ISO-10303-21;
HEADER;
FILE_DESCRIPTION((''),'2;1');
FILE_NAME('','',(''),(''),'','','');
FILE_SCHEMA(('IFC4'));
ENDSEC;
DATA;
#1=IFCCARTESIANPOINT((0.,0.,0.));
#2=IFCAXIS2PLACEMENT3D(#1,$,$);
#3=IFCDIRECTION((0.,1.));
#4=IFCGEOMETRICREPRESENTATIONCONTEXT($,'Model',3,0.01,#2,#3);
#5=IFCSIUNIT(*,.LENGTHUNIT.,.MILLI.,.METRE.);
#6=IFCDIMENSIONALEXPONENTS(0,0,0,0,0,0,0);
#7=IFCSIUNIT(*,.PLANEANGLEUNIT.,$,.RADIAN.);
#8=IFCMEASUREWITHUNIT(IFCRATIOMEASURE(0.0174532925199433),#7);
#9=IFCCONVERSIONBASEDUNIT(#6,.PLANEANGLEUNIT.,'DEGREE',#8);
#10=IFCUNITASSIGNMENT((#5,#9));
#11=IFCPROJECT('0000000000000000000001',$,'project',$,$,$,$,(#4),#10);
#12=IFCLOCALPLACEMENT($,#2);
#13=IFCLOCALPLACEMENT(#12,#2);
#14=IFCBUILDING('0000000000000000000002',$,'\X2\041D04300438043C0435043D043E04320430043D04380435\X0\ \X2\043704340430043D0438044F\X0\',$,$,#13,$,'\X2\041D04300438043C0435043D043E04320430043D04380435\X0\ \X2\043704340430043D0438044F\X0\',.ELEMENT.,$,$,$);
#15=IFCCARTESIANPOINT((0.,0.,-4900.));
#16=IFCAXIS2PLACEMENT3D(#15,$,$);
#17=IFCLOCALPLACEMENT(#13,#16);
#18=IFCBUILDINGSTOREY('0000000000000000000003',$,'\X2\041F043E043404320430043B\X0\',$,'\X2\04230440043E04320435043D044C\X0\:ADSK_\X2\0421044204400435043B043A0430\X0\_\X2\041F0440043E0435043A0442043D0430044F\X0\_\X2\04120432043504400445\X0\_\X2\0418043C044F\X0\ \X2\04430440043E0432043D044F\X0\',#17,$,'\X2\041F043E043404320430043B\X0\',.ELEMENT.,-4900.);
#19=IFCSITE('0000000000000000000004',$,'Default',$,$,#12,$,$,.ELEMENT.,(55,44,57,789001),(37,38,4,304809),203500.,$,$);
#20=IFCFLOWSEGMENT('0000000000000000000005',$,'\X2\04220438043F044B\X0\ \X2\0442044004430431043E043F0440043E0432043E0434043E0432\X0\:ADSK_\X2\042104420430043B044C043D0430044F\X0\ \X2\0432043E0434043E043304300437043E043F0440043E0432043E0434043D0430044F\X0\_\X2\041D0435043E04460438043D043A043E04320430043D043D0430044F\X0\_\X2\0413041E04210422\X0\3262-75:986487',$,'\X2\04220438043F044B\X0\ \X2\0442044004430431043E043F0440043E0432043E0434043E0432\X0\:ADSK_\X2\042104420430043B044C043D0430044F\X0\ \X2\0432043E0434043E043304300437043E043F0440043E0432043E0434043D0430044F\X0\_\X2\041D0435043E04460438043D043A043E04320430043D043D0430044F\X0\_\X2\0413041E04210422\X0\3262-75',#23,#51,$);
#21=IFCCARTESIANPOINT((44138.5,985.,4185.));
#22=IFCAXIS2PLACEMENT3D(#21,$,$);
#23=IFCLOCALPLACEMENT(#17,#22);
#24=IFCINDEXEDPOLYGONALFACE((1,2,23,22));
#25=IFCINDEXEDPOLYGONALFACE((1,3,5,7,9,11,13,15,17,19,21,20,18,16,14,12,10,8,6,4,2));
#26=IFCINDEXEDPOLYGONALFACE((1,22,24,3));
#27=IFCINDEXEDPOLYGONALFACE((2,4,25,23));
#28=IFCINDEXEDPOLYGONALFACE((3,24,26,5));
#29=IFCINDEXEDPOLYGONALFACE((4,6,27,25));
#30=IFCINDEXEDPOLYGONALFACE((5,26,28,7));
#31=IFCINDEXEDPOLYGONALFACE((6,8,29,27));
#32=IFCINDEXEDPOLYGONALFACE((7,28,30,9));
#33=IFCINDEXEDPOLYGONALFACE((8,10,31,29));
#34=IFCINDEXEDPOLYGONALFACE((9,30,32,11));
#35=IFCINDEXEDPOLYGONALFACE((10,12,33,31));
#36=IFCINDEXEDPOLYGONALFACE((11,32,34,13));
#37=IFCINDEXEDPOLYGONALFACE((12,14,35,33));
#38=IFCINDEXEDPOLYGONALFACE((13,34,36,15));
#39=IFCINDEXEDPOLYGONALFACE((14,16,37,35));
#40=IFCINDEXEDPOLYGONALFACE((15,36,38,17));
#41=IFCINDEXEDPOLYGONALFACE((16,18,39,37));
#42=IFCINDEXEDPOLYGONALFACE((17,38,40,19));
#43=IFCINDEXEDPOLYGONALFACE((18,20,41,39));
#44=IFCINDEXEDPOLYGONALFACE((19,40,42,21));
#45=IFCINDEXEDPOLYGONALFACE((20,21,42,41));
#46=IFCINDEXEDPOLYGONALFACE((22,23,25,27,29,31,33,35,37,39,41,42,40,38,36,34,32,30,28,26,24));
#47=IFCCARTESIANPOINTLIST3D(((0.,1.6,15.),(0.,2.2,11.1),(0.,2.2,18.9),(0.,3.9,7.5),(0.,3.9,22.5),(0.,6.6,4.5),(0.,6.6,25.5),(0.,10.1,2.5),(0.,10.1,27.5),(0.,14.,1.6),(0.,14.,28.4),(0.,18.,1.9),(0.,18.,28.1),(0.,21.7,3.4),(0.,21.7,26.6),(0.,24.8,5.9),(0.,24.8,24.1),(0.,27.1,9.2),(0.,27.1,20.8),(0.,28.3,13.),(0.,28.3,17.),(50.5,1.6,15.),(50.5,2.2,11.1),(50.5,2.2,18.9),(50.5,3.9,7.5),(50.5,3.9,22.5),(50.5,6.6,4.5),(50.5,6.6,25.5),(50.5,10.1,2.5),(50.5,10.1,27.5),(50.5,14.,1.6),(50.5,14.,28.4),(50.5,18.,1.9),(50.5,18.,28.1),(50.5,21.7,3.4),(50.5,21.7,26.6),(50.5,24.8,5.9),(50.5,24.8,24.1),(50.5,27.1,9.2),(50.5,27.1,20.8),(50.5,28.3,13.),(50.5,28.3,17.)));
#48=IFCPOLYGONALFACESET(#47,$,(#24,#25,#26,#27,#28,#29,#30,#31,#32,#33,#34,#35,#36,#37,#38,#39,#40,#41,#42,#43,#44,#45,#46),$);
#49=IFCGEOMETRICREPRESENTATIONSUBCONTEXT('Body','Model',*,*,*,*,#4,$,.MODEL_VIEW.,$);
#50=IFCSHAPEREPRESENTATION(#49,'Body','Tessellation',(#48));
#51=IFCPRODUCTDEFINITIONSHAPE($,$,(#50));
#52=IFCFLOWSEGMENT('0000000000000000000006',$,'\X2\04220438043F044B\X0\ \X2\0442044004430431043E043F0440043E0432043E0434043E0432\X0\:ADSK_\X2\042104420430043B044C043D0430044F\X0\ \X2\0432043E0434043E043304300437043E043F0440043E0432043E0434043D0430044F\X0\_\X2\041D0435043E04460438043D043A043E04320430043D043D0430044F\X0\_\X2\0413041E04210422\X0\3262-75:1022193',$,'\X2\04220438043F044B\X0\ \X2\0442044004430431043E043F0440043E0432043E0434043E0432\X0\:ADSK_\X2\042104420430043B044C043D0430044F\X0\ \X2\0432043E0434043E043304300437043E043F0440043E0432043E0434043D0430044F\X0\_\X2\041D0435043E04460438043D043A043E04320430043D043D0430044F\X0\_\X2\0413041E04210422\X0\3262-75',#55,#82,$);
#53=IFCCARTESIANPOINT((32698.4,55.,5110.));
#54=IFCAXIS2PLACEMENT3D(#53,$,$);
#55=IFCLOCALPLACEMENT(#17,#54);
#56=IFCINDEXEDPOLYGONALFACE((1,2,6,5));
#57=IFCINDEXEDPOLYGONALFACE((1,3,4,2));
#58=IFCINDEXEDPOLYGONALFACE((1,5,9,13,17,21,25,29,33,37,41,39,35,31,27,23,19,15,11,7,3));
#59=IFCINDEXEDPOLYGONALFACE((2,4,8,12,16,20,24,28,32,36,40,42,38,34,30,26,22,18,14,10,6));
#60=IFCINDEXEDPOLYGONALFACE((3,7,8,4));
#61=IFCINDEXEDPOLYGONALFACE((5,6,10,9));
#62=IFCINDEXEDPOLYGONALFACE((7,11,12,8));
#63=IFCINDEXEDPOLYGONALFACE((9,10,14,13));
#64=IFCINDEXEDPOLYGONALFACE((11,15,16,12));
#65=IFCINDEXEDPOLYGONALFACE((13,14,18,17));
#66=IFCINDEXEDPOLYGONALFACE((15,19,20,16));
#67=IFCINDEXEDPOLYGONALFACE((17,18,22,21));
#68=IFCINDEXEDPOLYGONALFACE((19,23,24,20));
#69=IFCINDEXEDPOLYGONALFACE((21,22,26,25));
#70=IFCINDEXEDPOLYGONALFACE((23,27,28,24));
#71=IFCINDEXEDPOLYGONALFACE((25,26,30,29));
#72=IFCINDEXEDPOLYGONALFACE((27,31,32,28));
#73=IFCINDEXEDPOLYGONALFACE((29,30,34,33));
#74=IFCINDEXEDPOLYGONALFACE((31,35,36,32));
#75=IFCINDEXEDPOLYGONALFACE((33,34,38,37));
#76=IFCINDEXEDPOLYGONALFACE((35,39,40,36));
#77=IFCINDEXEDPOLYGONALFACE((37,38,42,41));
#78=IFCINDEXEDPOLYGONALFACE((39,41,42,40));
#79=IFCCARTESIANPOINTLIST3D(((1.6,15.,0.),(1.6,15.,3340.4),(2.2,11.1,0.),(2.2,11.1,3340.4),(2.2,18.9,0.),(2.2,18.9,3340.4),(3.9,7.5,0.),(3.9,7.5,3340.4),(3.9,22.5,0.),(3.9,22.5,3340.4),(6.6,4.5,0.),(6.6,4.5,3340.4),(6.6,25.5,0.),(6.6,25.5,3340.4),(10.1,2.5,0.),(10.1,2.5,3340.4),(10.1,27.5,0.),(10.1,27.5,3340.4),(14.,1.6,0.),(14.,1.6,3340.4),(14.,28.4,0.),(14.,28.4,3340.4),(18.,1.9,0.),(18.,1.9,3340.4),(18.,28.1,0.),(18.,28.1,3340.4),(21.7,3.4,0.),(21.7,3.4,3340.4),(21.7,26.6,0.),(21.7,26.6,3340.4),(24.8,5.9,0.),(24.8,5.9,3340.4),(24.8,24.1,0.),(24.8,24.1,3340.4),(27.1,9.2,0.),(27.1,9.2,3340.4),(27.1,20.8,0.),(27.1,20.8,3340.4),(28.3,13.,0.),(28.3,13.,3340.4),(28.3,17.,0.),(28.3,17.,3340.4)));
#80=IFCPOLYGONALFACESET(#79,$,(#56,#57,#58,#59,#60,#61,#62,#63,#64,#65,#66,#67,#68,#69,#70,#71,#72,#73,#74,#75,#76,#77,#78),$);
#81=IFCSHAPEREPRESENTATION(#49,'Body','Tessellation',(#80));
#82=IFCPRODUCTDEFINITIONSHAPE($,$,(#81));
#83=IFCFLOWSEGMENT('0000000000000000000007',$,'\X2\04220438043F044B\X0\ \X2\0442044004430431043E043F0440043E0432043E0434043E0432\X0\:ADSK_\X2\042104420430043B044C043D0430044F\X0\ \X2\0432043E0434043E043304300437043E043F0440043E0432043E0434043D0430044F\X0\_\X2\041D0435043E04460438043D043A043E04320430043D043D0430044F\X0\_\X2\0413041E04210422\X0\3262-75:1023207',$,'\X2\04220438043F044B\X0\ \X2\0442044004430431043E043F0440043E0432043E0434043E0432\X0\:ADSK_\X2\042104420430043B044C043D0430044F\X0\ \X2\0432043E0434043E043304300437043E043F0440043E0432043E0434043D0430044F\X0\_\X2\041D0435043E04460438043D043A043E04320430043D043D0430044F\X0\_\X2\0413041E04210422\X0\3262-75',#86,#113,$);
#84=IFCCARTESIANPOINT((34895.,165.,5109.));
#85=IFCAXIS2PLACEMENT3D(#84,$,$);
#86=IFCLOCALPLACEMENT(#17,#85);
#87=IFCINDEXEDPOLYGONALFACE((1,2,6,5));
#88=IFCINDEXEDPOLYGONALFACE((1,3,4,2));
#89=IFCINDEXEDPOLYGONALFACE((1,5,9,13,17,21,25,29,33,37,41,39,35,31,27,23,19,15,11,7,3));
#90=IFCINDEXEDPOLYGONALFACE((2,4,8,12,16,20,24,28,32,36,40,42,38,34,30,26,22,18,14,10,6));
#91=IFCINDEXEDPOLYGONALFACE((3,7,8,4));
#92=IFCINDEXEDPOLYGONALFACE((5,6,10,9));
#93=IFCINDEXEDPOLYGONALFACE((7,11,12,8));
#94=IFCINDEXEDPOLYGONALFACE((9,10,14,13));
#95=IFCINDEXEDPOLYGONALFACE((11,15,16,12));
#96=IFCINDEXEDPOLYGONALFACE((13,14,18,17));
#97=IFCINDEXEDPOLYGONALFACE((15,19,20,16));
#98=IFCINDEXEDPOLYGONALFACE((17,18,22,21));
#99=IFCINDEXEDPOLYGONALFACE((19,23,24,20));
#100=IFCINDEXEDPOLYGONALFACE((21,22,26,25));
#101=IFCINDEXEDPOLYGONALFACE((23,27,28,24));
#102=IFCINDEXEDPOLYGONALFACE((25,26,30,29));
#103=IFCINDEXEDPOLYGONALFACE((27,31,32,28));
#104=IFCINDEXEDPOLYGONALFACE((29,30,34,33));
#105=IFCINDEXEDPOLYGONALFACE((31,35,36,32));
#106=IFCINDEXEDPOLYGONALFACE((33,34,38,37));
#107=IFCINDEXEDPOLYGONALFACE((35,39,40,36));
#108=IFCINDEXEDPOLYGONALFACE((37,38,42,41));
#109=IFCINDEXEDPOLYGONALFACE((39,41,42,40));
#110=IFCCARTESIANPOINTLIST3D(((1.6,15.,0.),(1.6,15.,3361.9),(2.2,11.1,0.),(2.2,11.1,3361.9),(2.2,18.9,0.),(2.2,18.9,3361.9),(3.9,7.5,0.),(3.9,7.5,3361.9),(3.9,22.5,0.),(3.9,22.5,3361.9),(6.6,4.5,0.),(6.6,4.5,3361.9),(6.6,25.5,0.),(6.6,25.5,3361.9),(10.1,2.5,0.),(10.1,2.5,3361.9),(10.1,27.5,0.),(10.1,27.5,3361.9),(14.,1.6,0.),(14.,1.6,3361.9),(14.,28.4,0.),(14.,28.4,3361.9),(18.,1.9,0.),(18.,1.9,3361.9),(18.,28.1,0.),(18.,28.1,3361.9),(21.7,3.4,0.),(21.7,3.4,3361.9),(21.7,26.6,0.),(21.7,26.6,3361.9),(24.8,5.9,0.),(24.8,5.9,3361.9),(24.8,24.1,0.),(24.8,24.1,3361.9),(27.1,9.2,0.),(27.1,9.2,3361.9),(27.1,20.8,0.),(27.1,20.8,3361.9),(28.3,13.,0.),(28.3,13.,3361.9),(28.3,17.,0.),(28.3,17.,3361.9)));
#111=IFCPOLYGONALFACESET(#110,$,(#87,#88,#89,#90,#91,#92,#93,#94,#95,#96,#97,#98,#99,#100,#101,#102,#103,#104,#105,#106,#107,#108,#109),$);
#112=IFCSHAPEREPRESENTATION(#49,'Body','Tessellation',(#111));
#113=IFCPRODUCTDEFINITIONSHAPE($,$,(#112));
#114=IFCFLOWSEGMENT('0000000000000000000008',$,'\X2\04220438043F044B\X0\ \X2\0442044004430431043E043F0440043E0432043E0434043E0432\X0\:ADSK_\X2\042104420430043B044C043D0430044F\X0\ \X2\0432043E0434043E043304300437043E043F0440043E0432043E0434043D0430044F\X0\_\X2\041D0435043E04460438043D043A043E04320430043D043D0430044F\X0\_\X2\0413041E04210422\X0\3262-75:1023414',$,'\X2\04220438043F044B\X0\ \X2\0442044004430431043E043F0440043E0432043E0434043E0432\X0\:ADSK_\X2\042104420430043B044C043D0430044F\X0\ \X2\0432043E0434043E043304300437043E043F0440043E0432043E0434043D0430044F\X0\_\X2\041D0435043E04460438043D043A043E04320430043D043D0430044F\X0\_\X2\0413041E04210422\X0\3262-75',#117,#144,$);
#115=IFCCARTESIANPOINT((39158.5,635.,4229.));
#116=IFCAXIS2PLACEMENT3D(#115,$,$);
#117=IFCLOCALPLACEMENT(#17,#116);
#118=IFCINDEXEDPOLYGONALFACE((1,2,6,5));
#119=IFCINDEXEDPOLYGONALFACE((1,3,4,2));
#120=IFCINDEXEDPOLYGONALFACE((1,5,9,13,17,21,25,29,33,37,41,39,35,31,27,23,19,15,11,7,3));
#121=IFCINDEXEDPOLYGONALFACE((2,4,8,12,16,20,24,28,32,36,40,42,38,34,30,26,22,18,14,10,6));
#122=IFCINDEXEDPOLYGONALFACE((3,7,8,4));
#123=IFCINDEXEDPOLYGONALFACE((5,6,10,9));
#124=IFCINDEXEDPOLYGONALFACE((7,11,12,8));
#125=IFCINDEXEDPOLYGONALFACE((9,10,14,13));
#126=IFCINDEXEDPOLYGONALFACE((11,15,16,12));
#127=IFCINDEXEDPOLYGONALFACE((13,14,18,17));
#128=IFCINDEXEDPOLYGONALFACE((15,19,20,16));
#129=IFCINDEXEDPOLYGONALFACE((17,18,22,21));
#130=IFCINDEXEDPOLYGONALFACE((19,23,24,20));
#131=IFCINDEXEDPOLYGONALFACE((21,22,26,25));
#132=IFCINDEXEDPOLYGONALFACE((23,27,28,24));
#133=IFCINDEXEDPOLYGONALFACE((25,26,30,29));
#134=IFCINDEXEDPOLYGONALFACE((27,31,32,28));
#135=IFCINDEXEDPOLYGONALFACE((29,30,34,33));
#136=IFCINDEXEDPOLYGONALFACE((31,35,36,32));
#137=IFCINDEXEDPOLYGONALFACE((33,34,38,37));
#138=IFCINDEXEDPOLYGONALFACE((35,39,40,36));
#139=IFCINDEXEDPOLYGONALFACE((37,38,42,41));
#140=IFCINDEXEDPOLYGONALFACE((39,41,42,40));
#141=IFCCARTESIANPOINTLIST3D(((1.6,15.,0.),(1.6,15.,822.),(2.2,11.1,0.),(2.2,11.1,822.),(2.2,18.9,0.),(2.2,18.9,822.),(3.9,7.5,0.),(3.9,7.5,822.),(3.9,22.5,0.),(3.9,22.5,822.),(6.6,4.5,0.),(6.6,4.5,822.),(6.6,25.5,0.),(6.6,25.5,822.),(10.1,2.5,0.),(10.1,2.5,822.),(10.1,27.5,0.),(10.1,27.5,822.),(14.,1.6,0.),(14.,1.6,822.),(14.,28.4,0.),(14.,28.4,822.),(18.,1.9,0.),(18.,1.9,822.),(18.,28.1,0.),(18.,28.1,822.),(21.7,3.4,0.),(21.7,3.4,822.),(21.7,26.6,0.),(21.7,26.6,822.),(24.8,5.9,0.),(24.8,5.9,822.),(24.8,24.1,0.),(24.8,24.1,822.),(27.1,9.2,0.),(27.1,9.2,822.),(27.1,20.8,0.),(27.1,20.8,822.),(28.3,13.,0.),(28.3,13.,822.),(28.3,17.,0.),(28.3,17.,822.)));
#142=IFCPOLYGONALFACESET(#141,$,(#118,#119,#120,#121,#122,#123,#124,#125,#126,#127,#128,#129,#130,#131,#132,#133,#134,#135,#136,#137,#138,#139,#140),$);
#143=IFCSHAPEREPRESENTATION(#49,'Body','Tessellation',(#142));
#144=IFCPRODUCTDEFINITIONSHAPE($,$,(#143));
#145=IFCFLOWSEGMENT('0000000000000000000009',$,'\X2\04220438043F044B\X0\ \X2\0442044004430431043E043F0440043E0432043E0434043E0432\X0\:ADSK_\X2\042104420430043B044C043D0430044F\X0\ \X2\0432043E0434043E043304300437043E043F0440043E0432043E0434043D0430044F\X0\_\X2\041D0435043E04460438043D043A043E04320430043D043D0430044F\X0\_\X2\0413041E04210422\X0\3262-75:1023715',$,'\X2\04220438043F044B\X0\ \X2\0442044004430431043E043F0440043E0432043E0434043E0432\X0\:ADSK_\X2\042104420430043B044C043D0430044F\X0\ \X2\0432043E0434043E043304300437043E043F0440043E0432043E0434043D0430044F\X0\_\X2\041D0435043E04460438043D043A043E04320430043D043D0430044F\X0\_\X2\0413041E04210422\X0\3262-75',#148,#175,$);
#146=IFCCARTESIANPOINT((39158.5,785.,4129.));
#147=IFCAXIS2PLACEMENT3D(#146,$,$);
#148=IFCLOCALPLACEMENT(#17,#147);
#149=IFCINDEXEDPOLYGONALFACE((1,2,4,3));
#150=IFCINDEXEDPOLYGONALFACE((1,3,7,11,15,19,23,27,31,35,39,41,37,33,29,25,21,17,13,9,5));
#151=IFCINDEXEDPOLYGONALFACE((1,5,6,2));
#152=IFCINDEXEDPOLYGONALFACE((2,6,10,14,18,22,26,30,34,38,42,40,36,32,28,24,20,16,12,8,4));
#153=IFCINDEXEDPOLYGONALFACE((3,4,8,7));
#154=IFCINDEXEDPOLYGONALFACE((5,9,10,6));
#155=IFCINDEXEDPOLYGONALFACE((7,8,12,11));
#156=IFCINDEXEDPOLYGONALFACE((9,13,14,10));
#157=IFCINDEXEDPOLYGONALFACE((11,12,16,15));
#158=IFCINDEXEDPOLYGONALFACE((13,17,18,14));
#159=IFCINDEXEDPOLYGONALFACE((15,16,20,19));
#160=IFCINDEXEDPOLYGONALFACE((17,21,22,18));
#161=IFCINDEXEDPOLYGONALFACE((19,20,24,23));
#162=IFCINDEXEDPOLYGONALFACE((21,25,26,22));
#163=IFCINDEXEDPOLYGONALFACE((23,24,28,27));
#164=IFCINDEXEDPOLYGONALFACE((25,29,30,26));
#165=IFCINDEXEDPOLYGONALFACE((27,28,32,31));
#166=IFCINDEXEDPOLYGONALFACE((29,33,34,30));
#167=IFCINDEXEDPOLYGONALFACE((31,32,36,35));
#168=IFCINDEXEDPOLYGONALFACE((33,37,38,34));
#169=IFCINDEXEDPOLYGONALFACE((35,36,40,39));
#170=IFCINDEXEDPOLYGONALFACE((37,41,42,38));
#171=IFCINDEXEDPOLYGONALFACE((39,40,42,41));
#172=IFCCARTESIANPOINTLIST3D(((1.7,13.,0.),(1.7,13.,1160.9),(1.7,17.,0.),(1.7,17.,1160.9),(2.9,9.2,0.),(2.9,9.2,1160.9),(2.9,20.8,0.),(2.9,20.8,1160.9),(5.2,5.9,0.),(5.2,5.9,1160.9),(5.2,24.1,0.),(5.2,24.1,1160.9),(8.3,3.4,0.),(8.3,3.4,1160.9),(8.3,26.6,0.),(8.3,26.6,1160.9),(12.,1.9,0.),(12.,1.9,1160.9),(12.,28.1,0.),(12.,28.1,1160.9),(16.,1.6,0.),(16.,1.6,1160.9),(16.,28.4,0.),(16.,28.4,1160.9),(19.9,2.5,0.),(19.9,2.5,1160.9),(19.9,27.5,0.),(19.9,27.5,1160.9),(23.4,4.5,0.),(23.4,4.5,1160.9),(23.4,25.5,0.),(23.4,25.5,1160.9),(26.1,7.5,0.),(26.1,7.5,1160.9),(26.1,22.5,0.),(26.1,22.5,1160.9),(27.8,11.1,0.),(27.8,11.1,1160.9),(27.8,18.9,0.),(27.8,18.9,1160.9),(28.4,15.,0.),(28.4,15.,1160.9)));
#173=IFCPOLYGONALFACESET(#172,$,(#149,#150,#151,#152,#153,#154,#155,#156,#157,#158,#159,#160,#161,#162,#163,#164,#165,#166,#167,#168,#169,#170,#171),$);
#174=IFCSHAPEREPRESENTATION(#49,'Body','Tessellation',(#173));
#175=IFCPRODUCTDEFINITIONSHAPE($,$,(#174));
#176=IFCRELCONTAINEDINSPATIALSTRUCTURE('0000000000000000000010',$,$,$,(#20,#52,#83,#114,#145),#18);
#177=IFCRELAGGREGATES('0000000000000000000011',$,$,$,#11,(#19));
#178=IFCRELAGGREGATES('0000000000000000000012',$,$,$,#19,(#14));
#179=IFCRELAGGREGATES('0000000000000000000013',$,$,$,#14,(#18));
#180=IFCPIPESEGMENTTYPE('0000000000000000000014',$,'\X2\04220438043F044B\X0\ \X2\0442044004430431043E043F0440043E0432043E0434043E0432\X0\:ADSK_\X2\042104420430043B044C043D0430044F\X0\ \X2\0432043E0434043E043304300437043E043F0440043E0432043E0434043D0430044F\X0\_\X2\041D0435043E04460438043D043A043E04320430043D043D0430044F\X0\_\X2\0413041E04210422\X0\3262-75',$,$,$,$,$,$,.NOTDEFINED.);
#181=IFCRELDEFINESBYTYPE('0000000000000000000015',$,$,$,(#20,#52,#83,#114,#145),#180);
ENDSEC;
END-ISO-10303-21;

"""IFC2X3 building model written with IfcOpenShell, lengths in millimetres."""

from ifc_helpers import new_model, entity, si_unit, converted_unit, direction, frame, origin, origin_2d_with_axis, place, context, subcontext, project, spatial, circle, extrude, type_object, element, save


model = new_model("IFC2X3")

# Units and contexts
model_context = context("Model", 3, precision=0.01, world=origin(), true_north=direction((0.0, 1.0)))
body_context = subcontext(model_context, "Body", "Model", "MODEL_VIEW")
ifc_project = project(units=[si_unit("LENGTHUNIT", "METRE", prefix="MILLI"), converted_unit("PLANEANGLEUNIT", "DEGREE", entity("IfcRatioMeasure", 0.0174532925199433), si_unit("PLANEANGLEUNIT", "RADIAN"), dimensions=[0, 0, 0, 0, 0, 0, 0])], contexts=[model_context])

# Site, building, storey
site_placement = place(None, origin())
site = spatial("IfcSite", under=ifc_project, at=site_placement, Name="Default", CompositionType="ELEMENT", RefLatitude=(55, 44, 57, 789001), RefLongitude=(37, 38, 4, 304809), RefElevation=203500.0)
building_placement = place(site_placement, origin())
building = spatial("IfcBuilding", under=site, at=building_placement, Name="Наименование здания", LongName="Наименование здания", CompositionType="ELEMENT")
storey_placement = place(building_placement, frame((0.0, 0.0, -4900.0)))
storey = spatial("IfcBuildingStorey", under=building, at=storey_placement, Name="Подвал", ObjectType="Уровень:ADSK_Стрелка_Проектная_Вверх_Имя уровня", LongName="Подвал", CompositionType="ELEMENT", Elevation=-4900.0)

# Flow segments
pipe_segment_type = type_object("IfcPipeSegmentType", Name="Типы трубопроводов:ADSK_Стальная водогазопроводная_Неоцинкованная_ГОСТ3262-75", PredefinedType="NOTDEFINED")
flow_segment_1_placement = place(storey_placement, frame((44138.5, 985.0, 4185.0)))
element("IfcFlowSegment", 1, at=flow_segment_1_placement, inside=storey, type_object=pipe_segment_type, Name="Типы трубопроводов:ADSK_Стальная водогазопроводная_Неоцинкованная_ГОСТ3262-75:986487", ObjectType="Типы трубопроводов:ADSK_Стальная водогазопроводная_Неоцинкованная_ГОСТ3262-75", context=body_context, shape_type="SweptSolid", body=[
    extrude(circle(Radius=13.4, at=origin_2d_with_axis()), frame((0.0, 15.0, 15.0), z_axis=(1.0, 0.0, 0.0), x_axis=(0.0, -1.0, 0.0)), (0.0, 0.0, 1.0), 50.5),
])
flow_segment_2_placement = place(storey_placement, frame((32698.4, 55.0, 5110.0)))
element("IfcFlowSegment", 2, at=flow_segment_2_placement, inside=storey, type_object=pipe_segment_type, Name="Типы трубопроводов:ADSK_Стальная водогазопроводная_Неоцинкованная_ГОСТ3262-75:1022193", ObjectType="Типы трубопроводов:ADSK_Стальная водогазопроводная_Неоцинкованная_ГОСТ3262-75", context=body_context, shape_type="SweptSolid", body=[
    extrude(circle(Radius=13.4, at=origin_2d_with_axis()), frame((15.0, 15.0, 0.0), z_axis=(0.0, 0.0, 1.0), x_axis=(-1.0, 0.0, 0.0)), (0.0, 0.0, 1.0), 3340.4),
])
flow_segment_3_placement = place(storey_placement, frame((34895.0, 165.0, 5109.0)))
element("IfcFlowSegment", 3, at=flow_segment_3_placement, inside=storey, type_object=pipe_segment_type, Name="Типы трубопроводов:ADSK_Стальная водогазопроводная_Неоцинкованная_ГОСТ3262-75:1023207", ObjectType="Типы трубопроводов:ADSK_Стальная водогазопроводная_Неоцинкованная_ГОСТ3262-75", context=body_context, shape_type="SweptSolid", body=[
    extrude(circle(Radius=13.4, at=origin_2d_with_axis()), frame((15.0, 15.0, 0.0), z_axis=(0.0, 0.0, 1.0), x_axis=(-1.0, 0.0, 0.0)), (0.0, 0.0, 1.0), 3361.9),
])
flow_segment_4_placement = place(storey_placement, frame((39158.5, 635.0, 4229.0)))
element("IfcFlowSegment", 4, at=flow_segment_4_placement, inside=storey, type_object=pipe_segment_type, Name="Типы трубопроводов:ADSK_Стальная водогазопроводная_Неоцинкованная_ГОСТ3262-75:1023414", ObjectType="Типы трубопроводов:ADSK_Стальная водогазопроводная_Неоцинкованная_ГОСТ3262-75", context=body_context, shape_type="SweptSolid", body=[
    extrude(circle(Radius=13.4, at=origin_2d_with_axis()), frame((15.0, 15.0, 0.0), z_axis=(0.0, 0.0, 1.0), x_axis=(-1.0, 0.0, 0.0)), (0.0, 0.0, 1.0), 822.0),
])
flow_segment_5_placement = place(storey_placement, frame((39158.5, 785.0, 4129.0)))
element("IfcFlowSegment", 5, at=flow_segment_5_placement, inside=storey, type_object=pipe_segment_type, Name="Типы трубопроводов:ADSK_Стальная водогазопроводная_Неоцинкованная_ГОСТ3262-75:1023715", ObjectType="Типы трубопроводов:ADSK_Стальная водогазопроводная_Неоцинкованная_ГОСТ3262-75", context=body_context, shape_type="SweptSolid", body=[
    extrude(circle(Radius=13.4, at=origin_2d_with_axis()), frame((15.0, 15.0, 0.0)), (0.0, 0.0, 1.0), 1160.9),
])

save(model, "model.ifc")
